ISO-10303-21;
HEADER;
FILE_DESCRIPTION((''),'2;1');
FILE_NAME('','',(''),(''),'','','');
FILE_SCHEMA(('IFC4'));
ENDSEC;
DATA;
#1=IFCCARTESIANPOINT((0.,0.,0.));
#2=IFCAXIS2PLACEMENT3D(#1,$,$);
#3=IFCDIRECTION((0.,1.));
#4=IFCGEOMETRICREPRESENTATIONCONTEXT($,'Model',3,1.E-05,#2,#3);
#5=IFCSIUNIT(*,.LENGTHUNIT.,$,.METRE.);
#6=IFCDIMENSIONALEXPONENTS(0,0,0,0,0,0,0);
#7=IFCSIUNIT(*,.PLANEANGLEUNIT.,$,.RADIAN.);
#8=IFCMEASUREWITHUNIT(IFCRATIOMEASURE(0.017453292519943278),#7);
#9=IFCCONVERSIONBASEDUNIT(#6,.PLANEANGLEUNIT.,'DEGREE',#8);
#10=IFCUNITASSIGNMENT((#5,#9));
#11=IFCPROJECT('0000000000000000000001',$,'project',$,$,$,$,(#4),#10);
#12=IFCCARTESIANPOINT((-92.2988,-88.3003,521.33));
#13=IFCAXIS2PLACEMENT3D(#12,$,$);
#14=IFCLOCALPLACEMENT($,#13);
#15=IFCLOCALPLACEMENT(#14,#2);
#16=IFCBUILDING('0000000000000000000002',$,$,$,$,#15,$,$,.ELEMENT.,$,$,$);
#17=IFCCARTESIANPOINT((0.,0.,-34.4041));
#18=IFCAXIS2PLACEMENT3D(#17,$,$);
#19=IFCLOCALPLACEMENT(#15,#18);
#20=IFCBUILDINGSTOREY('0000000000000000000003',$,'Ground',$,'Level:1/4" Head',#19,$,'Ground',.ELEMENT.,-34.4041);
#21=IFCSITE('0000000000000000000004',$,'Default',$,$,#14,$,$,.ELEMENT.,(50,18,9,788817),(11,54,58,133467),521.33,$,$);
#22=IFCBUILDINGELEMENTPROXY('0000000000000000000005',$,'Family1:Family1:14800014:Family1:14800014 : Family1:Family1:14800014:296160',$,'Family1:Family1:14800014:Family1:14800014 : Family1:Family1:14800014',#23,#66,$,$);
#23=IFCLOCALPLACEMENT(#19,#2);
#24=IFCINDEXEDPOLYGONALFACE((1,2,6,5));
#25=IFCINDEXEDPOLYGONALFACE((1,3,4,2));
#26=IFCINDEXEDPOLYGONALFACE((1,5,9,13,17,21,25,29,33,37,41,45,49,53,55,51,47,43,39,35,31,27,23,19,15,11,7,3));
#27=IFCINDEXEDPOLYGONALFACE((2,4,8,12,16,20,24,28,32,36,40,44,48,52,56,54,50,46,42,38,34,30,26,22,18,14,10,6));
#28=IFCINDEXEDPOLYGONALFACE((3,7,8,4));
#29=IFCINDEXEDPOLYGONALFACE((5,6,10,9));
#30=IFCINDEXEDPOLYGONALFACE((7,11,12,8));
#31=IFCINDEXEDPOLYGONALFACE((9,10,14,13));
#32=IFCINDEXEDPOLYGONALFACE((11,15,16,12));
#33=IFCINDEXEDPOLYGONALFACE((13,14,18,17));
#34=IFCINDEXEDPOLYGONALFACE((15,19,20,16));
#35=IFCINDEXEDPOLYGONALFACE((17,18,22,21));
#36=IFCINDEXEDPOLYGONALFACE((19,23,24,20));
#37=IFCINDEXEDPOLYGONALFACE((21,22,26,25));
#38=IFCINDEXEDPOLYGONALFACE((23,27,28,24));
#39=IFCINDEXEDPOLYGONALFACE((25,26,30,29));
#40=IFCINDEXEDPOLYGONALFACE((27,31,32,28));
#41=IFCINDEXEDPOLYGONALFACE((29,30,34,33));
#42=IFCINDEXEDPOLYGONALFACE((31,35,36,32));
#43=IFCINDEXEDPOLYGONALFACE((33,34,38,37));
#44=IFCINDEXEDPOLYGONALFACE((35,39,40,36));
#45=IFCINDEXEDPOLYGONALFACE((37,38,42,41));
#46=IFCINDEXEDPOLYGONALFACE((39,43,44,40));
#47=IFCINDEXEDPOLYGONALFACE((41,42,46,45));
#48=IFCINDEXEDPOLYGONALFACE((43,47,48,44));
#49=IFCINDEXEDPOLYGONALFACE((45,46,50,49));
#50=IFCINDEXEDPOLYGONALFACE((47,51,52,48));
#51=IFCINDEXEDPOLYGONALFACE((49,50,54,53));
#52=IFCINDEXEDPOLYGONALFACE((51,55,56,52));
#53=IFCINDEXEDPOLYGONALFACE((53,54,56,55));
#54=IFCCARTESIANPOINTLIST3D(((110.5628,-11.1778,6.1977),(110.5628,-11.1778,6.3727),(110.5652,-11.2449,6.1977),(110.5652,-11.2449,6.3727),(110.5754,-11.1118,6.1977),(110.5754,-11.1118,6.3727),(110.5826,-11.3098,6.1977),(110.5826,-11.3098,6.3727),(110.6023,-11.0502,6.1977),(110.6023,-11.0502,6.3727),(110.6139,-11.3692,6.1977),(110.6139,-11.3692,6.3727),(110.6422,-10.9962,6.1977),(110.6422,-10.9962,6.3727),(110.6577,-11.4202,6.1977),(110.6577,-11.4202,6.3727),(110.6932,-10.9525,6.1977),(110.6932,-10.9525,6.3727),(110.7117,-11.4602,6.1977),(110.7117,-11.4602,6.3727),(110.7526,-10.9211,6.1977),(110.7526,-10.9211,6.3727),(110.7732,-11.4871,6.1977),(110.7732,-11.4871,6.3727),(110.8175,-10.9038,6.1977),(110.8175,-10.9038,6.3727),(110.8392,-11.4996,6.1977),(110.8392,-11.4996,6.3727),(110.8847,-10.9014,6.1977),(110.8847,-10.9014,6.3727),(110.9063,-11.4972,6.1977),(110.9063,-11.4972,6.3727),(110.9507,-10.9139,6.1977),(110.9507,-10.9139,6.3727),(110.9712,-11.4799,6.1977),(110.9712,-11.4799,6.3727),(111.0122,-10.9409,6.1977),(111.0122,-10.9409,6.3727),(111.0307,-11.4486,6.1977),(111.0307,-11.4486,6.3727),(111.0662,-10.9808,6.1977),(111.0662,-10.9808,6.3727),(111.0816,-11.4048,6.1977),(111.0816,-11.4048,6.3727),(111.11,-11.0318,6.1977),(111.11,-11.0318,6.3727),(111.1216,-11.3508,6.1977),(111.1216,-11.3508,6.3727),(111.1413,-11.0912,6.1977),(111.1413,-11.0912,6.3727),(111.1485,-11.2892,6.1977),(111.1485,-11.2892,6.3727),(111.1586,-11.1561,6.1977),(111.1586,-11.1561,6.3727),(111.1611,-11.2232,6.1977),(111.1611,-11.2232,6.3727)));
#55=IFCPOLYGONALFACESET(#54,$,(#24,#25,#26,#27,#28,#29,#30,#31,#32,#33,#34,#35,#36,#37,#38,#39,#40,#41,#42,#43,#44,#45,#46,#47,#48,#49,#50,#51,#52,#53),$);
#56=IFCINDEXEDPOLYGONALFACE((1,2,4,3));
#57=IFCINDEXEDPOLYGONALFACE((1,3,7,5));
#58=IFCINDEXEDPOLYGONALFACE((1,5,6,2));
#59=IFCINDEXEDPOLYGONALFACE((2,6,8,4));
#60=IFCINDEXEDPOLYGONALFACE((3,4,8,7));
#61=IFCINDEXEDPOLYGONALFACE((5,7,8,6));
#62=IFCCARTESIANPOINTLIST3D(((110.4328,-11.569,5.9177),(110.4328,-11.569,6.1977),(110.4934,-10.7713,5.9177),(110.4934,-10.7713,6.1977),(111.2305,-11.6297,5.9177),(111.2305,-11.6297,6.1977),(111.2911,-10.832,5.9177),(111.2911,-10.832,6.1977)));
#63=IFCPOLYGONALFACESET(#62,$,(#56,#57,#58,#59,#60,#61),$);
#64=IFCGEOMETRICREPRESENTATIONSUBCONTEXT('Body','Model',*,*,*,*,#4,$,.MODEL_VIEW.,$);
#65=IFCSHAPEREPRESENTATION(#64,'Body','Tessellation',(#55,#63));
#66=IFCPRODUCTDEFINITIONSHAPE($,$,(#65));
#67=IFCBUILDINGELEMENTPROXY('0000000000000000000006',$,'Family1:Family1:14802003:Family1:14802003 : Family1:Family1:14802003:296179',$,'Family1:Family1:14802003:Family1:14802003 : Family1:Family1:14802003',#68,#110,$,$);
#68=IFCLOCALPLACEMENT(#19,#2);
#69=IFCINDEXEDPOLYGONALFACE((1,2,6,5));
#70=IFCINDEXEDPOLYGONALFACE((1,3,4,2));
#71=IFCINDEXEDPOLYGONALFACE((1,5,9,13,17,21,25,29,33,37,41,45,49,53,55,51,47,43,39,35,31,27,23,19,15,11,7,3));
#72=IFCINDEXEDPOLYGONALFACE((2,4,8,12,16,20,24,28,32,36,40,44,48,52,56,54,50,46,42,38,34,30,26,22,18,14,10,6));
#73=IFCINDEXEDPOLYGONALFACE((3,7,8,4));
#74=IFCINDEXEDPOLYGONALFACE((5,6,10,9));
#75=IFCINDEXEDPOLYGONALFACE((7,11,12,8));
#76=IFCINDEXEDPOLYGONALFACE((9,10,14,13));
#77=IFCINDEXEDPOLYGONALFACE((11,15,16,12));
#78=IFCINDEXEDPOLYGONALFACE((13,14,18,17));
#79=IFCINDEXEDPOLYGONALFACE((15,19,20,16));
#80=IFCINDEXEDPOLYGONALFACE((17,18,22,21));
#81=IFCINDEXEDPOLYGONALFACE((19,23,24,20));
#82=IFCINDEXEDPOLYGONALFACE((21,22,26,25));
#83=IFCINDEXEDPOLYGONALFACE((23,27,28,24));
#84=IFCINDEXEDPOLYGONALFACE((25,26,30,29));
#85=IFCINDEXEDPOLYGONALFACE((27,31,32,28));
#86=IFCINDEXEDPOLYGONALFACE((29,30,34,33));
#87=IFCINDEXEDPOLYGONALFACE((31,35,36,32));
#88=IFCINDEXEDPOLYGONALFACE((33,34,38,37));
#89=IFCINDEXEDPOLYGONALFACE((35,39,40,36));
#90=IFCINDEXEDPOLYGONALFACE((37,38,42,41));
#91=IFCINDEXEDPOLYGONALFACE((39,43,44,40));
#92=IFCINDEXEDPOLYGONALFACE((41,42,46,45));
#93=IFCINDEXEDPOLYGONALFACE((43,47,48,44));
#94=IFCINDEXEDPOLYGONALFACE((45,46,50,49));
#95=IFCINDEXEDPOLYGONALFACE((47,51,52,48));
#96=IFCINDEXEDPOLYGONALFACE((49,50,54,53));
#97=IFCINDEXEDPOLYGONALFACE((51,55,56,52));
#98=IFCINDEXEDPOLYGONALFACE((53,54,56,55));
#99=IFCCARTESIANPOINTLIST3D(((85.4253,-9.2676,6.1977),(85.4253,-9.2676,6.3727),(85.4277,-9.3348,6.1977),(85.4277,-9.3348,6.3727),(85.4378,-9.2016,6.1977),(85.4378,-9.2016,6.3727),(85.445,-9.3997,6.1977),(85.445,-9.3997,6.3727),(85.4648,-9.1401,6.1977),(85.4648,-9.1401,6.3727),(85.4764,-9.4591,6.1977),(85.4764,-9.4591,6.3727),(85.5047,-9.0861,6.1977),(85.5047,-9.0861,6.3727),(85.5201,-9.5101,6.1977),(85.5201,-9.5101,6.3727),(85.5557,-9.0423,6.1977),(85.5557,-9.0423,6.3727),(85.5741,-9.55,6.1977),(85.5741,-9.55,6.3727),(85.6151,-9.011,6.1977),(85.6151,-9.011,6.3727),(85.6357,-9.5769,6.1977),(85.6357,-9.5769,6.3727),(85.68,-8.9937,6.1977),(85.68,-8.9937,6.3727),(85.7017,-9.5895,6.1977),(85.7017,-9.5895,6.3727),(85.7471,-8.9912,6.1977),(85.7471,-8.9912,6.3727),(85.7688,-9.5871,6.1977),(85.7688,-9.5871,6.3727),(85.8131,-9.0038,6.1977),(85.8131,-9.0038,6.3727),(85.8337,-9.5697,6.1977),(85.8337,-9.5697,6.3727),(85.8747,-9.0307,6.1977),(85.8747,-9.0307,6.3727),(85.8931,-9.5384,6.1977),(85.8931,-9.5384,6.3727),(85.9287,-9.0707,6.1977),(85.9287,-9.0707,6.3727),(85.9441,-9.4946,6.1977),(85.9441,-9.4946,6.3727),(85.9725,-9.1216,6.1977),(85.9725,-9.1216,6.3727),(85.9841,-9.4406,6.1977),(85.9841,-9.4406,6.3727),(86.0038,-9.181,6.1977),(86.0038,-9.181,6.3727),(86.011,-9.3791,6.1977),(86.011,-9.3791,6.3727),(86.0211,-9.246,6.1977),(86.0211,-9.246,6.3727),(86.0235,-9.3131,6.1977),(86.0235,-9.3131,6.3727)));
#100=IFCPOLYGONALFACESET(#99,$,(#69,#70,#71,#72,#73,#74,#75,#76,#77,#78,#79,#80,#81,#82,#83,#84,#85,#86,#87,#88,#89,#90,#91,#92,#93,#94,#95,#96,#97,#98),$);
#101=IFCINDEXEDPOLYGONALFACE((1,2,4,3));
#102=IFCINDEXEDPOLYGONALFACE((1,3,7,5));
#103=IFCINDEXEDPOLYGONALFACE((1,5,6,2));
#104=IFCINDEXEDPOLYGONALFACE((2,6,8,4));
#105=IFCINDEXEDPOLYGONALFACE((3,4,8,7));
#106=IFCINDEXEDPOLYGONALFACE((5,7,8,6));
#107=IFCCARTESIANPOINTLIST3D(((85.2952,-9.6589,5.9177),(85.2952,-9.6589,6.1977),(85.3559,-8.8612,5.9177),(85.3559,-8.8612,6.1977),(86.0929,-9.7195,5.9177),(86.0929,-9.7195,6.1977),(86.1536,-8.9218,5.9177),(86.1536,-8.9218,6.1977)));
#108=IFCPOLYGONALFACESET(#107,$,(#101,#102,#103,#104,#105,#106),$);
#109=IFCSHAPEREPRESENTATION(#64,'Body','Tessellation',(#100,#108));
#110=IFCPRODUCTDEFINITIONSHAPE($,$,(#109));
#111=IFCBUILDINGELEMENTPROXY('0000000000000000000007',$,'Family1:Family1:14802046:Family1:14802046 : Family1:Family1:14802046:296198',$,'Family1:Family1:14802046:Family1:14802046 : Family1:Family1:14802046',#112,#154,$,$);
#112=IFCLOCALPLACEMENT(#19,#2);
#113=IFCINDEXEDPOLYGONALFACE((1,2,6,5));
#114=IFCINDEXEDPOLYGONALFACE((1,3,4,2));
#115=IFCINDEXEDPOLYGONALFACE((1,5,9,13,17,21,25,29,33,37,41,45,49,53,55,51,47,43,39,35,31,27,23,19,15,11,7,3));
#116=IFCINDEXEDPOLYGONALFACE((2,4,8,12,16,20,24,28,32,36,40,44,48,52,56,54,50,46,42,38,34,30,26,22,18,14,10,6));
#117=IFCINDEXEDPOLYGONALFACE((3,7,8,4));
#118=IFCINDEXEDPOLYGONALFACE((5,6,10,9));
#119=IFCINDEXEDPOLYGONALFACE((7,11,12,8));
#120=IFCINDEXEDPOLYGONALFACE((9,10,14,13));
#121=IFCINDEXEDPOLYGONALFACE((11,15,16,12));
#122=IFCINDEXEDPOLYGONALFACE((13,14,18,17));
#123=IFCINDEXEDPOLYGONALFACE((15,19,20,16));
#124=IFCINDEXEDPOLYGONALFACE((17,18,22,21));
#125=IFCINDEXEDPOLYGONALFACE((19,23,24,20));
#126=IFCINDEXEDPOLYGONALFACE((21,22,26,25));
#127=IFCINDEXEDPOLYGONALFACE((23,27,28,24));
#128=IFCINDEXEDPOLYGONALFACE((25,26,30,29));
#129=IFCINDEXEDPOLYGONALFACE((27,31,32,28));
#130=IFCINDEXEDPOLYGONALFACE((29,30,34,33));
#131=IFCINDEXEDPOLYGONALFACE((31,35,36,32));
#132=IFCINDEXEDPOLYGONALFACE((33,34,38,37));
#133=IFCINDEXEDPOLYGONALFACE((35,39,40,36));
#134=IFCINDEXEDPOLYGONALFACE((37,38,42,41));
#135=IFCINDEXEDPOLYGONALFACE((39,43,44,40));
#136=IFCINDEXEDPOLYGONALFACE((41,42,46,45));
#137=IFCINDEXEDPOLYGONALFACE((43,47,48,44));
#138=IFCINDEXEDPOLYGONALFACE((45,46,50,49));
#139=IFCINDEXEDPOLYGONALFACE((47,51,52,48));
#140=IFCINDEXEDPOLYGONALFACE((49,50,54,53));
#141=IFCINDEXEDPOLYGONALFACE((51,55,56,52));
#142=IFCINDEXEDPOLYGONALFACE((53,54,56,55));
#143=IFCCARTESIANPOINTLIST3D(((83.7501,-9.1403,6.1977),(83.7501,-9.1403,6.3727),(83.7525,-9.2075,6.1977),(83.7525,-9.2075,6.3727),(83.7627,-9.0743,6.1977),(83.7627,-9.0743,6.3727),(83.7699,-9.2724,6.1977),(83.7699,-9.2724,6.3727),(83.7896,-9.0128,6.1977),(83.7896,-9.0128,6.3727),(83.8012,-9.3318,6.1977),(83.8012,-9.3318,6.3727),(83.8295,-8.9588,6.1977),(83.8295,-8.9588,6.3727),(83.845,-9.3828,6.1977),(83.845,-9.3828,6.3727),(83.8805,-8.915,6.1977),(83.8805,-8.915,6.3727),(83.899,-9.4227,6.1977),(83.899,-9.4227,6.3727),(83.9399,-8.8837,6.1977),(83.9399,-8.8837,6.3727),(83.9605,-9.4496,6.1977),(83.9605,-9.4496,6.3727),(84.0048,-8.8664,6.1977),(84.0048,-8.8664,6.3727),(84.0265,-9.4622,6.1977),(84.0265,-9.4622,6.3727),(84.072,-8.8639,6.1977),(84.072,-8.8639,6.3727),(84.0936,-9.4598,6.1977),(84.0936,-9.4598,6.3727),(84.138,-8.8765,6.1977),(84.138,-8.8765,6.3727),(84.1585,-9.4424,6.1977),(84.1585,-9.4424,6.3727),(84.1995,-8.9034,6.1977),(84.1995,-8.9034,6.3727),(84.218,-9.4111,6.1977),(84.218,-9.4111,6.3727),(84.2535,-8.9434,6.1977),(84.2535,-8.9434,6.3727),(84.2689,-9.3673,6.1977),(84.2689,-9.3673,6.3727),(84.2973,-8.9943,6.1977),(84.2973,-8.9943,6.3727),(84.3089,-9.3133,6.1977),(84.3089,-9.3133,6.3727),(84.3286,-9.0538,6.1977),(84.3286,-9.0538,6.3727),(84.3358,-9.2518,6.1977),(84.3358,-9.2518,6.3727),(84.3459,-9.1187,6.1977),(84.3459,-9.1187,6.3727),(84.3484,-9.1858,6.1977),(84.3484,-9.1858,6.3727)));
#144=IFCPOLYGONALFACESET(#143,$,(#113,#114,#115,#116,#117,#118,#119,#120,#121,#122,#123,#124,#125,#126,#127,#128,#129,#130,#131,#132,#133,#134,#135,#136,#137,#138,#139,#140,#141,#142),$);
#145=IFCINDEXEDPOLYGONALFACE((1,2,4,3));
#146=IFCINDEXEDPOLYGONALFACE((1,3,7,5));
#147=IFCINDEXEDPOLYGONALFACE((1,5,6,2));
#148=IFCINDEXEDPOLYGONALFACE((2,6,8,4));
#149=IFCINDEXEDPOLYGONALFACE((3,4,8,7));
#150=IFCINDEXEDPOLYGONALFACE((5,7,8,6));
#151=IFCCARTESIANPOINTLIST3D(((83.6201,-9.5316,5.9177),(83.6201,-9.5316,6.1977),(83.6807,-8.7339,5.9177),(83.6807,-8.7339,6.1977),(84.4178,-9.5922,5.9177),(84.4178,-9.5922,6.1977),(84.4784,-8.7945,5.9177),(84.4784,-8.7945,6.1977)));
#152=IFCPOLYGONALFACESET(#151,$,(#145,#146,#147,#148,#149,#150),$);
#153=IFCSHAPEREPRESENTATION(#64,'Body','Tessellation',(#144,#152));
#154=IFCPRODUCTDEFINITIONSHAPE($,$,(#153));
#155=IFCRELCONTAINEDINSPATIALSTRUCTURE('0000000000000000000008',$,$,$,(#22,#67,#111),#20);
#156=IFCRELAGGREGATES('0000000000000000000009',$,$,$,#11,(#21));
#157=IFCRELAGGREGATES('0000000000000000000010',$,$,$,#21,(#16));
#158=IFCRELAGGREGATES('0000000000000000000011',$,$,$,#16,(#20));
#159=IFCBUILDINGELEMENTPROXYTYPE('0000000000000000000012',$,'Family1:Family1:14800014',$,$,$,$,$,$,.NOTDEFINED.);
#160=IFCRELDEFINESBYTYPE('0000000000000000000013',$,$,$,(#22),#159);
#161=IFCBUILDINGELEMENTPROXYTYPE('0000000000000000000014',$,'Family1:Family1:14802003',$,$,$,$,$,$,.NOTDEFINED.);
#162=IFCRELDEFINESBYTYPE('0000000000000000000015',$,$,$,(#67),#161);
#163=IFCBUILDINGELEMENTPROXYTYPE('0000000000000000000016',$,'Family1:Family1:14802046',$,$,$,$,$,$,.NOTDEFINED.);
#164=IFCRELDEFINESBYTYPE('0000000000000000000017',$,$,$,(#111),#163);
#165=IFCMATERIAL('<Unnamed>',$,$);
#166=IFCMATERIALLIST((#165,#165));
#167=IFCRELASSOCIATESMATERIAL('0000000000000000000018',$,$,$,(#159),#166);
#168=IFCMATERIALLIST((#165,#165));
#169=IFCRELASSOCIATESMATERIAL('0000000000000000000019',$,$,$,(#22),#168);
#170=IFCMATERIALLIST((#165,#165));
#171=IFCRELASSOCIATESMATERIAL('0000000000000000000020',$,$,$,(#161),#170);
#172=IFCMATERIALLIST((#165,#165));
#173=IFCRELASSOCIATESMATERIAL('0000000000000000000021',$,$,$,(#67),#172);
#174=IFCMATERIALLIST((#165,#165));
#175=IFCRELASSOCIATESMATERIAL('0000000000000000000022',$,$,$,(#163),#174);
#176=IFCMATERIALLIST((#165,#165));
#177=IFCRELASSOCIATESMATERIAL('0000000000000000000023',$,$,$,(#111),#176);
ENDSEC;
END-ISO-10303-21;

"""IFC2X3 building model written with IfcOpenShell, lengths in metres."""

from ifc_helpers import new_model, entity, si_unit, converted_unit, direction, frame, frame_2d, origin, origin_2d_with_axis, place, context, subcontext, project, spatial, rectangle, circle, extrude, source, transform, mapped, material, material_list, type_object, type_shapes, element, save


model = new_model("IFC2X3")

# Units and contexts
model_context = context("Model", 3, precision=1e-05, world=origin(), true_north=direction((0.0, 1.0)))
body_context = subcontext(model_context, "Body", "Model", "MODEL_VIEW")
ifc_project = project(units=[si_unit("LENGTHUNIT", "METRE"), converted_unit("PLANEANGLEUNIT", "DEGREE", entity("IfcRatioMeasure", 0.017453292519943278), si_unit("PLANEANGLEUNIT", "RADIAN"), dimensions=[0, 0, 0, 0, 0, 0, 0])], contexts=[model_context])

# Site, building, storey
site_placement = place(None, frame((-92.2988, -88.3003, 521.33)))
site = spatial("IfcSite", under=ifc_project, at=site_placement, Name="Default", CompositionType="ELEMENT", RefLatitude=(50, 18, 9, 788817), RefLongitude=(11, 54, 58, 133467), RefElevation=521.33)
building_placement = place(site_placement, origin())
building = spatial("IfcBuilding", under=site, at=building_placement, CompositionType="ELEMENT")
storey_placement = place(building_placement, frame((0.0, 0.0, -34.4041)))
storey = spatial("IfcBuildingStorey", under=building, at=storey_placement, Name="Ground", ObjectType="Level:1/4\" Head", LongName="Ground", CompositionType="ELEMENT", Elevation=-34.4041)

# Building element proxies
ifc_material_1 = material(Name="<Unnamed>")
ifc_material_list_1 = material_list([ifc_material_1, ifc_material_1])
ifc_material_list_2 = material_list([ifc_material_1, ifc_material_1])
building_element_proxy_type_1 = type_object("IfcBuildingElementProxyType", Name="Family1:Family1:14800014", PredefinedType="NOTDEFINED", material=ifc_material_list_2)
shared_shape_1 = source(origin(), body_context, "Body", "SweptSolid", [
    extrude(circle(Radius=0.3, at=frame_2d((0.0, 0.0), x_axis=(1.0, 0.0))), frame((110.8619, -11.2005, -28.2064), z_axis=(0.0, 0.0, 1.0), x_axis=(0.997125, -0.07577, 0.0)), (0.0, 0.0, 1.0), 0.175),
    extrude(rectangle(XDim=0.8, YDim=0.8, at=origin_2d_with_axis()), frame((110.8619, -11.2005, -28.4864), z_axis=(0.0, 0.0, 1.0), x_axis=(-0.07577, -0.997125, 0.0)), (0.0, 0.0, 1.0), 0.28),
])
type_shapes(building_element_proxy_type_1, [shared_shape_1])
proxy_1_placement = place(storey_placement, frame((0.0, 0.0, 34.4041)))
element("IfcBuildingElementProxy", 1, at=proxy_1_placement, inside=storey, type_object=building_element_proxy_type_1, material=ifc_material_list_1, Name="Family1:Family1:14800014:Family1:14800014 : Family1:Family1:14800014:296160", ObjectType="Family1:Family1:14800014:Family1:14800014 : Family1:Family1:14800014", context=body_context, shape_type="MappedRepresentation", body=[
    mapped(shared_shape_1, transform((0.0, 0.0, 0.0), scale=1.0)),
])
ifc_material_list_3 = material_list([ifc_material_1, ifc_material_1])
ifc_material_list_4 = material_list([ifc_material_1, ifc_material_1])
building_element_proxy_type_2 = type_object("IfcBuildingElementProxyType", Name="Family1:Family1:14802003", PredefinedType="NOTDEFINED", material=ifc_material_list_4)
shared_shape_2 = source(origin(), body_context, "Body", "SweptSolid", [
    extrude(circle(Radius=0.3, at=frame_2d((0.0, 0.0), x_axis=(1.0, 0.0))), frame((85.7244, -9.2904, -28.2064), z_axis=(0.0, 0.0, 1.0), x_axis=(0.997125, -0.07577, 0.0)), (0.0, 0.0, 1.0), 0.175),
    extrude(rectangle(XDim=0.8, YDim=0.8, at=frame_2d((0.0, 0.0), x_axis=(1.0, 0.0))), frame((85.7244, -9.2904, -28.4864), z_axis=(0.0, 0.0, 1.0), x_axis=(-0.07577, -0.997125, 0.0)), (0.0, 0.0, 1.0), 0.28),
])
type_shapes(building_element_proxy_type_2, [shared_shape_2])
proxy_2_placement = place(storey_placement, frame((0.0, 0.0, 34.4041)))
element("IfcBuildingElementProxy", 2, at=proxy_2_placement, inside=storey, type_object=building_element_proxy_type_2, material=ifc_material_list_3, Name="Family1:Family1:14802003:Family1:14802003 : Family1:Family1:14802003:296179", ObjectType="Family1:Family1:14802003:Family1:14802003 : Family1:Family1:14802003", context=body_context, shape_type="MappedRepresentation", body=[
    mapped(shared_shape_2, transform((0.0, 0.0, 0.0), scale=1.0)),
])
ifc_material_list_5 = material_list([ifc_material_1, ifc_material_1])
ifc_material_list_6 = material_list([ifc_material_1, ifc_material_1])
building_element_proxy_type_3 = type_object("IfcBuildingElementProxyType", Name="Family1:Family1:14802046", PredefinedType="NOTDEFINED", material=ifc_material_list_6)
shared_shape_3 = source(origin(), body_context, "Body", "SweptSolid", [
    extrude(circle(Radius=0.3, at=frame_2d((0.0, 0.0), x_axis=(1.0, 0.0))), frame((84.0492, -9.1631, -28.2064), z_axis=(0.0, 0.0, 1.0), x_axis=(0.997125, -0.07577, 0.0)), (0.0, 0.0, 1.0), 0.175),
    extrude(rectangle(XDim=0.8, YDim=0.8, at=frame_2d((0.0, 0.0), x_axis=(1.0, 0.0))), frame((84.0492, -9.1631, -28.4864), z_axis=(0.0, 0.0, 1.0), x_axis=(-0.07577, -0.997125, 0.0)), (0.0, 0.0, 1.0), 0.28),
])
type_shapes(building_element_proxy_type_3, [shared_shape_3])
proxy_3_placement = place(storey_placement, frame((0.0, 0.0, 34.4041)))
element("IfcBuildingElementProxy", 3, at=proxy_3_placement, inside=storey, type_object=building_element_proxy_type_3, material=ifc_material_list_5, Name="Family1:Family1:14802046:Family1:14802046 : Family1:Family1:14802046:296198", ObjectType="Family1:Family1:14802046:Family1:14802046 : Family1:Family1:14802046", context=body_context, shape_type="MappedRepresentation", body=[
    mapped(shared_shape_3, transform((0.0, 0.0, 0.0), scale=1.0)),
])

save(model, "model.ifc")
